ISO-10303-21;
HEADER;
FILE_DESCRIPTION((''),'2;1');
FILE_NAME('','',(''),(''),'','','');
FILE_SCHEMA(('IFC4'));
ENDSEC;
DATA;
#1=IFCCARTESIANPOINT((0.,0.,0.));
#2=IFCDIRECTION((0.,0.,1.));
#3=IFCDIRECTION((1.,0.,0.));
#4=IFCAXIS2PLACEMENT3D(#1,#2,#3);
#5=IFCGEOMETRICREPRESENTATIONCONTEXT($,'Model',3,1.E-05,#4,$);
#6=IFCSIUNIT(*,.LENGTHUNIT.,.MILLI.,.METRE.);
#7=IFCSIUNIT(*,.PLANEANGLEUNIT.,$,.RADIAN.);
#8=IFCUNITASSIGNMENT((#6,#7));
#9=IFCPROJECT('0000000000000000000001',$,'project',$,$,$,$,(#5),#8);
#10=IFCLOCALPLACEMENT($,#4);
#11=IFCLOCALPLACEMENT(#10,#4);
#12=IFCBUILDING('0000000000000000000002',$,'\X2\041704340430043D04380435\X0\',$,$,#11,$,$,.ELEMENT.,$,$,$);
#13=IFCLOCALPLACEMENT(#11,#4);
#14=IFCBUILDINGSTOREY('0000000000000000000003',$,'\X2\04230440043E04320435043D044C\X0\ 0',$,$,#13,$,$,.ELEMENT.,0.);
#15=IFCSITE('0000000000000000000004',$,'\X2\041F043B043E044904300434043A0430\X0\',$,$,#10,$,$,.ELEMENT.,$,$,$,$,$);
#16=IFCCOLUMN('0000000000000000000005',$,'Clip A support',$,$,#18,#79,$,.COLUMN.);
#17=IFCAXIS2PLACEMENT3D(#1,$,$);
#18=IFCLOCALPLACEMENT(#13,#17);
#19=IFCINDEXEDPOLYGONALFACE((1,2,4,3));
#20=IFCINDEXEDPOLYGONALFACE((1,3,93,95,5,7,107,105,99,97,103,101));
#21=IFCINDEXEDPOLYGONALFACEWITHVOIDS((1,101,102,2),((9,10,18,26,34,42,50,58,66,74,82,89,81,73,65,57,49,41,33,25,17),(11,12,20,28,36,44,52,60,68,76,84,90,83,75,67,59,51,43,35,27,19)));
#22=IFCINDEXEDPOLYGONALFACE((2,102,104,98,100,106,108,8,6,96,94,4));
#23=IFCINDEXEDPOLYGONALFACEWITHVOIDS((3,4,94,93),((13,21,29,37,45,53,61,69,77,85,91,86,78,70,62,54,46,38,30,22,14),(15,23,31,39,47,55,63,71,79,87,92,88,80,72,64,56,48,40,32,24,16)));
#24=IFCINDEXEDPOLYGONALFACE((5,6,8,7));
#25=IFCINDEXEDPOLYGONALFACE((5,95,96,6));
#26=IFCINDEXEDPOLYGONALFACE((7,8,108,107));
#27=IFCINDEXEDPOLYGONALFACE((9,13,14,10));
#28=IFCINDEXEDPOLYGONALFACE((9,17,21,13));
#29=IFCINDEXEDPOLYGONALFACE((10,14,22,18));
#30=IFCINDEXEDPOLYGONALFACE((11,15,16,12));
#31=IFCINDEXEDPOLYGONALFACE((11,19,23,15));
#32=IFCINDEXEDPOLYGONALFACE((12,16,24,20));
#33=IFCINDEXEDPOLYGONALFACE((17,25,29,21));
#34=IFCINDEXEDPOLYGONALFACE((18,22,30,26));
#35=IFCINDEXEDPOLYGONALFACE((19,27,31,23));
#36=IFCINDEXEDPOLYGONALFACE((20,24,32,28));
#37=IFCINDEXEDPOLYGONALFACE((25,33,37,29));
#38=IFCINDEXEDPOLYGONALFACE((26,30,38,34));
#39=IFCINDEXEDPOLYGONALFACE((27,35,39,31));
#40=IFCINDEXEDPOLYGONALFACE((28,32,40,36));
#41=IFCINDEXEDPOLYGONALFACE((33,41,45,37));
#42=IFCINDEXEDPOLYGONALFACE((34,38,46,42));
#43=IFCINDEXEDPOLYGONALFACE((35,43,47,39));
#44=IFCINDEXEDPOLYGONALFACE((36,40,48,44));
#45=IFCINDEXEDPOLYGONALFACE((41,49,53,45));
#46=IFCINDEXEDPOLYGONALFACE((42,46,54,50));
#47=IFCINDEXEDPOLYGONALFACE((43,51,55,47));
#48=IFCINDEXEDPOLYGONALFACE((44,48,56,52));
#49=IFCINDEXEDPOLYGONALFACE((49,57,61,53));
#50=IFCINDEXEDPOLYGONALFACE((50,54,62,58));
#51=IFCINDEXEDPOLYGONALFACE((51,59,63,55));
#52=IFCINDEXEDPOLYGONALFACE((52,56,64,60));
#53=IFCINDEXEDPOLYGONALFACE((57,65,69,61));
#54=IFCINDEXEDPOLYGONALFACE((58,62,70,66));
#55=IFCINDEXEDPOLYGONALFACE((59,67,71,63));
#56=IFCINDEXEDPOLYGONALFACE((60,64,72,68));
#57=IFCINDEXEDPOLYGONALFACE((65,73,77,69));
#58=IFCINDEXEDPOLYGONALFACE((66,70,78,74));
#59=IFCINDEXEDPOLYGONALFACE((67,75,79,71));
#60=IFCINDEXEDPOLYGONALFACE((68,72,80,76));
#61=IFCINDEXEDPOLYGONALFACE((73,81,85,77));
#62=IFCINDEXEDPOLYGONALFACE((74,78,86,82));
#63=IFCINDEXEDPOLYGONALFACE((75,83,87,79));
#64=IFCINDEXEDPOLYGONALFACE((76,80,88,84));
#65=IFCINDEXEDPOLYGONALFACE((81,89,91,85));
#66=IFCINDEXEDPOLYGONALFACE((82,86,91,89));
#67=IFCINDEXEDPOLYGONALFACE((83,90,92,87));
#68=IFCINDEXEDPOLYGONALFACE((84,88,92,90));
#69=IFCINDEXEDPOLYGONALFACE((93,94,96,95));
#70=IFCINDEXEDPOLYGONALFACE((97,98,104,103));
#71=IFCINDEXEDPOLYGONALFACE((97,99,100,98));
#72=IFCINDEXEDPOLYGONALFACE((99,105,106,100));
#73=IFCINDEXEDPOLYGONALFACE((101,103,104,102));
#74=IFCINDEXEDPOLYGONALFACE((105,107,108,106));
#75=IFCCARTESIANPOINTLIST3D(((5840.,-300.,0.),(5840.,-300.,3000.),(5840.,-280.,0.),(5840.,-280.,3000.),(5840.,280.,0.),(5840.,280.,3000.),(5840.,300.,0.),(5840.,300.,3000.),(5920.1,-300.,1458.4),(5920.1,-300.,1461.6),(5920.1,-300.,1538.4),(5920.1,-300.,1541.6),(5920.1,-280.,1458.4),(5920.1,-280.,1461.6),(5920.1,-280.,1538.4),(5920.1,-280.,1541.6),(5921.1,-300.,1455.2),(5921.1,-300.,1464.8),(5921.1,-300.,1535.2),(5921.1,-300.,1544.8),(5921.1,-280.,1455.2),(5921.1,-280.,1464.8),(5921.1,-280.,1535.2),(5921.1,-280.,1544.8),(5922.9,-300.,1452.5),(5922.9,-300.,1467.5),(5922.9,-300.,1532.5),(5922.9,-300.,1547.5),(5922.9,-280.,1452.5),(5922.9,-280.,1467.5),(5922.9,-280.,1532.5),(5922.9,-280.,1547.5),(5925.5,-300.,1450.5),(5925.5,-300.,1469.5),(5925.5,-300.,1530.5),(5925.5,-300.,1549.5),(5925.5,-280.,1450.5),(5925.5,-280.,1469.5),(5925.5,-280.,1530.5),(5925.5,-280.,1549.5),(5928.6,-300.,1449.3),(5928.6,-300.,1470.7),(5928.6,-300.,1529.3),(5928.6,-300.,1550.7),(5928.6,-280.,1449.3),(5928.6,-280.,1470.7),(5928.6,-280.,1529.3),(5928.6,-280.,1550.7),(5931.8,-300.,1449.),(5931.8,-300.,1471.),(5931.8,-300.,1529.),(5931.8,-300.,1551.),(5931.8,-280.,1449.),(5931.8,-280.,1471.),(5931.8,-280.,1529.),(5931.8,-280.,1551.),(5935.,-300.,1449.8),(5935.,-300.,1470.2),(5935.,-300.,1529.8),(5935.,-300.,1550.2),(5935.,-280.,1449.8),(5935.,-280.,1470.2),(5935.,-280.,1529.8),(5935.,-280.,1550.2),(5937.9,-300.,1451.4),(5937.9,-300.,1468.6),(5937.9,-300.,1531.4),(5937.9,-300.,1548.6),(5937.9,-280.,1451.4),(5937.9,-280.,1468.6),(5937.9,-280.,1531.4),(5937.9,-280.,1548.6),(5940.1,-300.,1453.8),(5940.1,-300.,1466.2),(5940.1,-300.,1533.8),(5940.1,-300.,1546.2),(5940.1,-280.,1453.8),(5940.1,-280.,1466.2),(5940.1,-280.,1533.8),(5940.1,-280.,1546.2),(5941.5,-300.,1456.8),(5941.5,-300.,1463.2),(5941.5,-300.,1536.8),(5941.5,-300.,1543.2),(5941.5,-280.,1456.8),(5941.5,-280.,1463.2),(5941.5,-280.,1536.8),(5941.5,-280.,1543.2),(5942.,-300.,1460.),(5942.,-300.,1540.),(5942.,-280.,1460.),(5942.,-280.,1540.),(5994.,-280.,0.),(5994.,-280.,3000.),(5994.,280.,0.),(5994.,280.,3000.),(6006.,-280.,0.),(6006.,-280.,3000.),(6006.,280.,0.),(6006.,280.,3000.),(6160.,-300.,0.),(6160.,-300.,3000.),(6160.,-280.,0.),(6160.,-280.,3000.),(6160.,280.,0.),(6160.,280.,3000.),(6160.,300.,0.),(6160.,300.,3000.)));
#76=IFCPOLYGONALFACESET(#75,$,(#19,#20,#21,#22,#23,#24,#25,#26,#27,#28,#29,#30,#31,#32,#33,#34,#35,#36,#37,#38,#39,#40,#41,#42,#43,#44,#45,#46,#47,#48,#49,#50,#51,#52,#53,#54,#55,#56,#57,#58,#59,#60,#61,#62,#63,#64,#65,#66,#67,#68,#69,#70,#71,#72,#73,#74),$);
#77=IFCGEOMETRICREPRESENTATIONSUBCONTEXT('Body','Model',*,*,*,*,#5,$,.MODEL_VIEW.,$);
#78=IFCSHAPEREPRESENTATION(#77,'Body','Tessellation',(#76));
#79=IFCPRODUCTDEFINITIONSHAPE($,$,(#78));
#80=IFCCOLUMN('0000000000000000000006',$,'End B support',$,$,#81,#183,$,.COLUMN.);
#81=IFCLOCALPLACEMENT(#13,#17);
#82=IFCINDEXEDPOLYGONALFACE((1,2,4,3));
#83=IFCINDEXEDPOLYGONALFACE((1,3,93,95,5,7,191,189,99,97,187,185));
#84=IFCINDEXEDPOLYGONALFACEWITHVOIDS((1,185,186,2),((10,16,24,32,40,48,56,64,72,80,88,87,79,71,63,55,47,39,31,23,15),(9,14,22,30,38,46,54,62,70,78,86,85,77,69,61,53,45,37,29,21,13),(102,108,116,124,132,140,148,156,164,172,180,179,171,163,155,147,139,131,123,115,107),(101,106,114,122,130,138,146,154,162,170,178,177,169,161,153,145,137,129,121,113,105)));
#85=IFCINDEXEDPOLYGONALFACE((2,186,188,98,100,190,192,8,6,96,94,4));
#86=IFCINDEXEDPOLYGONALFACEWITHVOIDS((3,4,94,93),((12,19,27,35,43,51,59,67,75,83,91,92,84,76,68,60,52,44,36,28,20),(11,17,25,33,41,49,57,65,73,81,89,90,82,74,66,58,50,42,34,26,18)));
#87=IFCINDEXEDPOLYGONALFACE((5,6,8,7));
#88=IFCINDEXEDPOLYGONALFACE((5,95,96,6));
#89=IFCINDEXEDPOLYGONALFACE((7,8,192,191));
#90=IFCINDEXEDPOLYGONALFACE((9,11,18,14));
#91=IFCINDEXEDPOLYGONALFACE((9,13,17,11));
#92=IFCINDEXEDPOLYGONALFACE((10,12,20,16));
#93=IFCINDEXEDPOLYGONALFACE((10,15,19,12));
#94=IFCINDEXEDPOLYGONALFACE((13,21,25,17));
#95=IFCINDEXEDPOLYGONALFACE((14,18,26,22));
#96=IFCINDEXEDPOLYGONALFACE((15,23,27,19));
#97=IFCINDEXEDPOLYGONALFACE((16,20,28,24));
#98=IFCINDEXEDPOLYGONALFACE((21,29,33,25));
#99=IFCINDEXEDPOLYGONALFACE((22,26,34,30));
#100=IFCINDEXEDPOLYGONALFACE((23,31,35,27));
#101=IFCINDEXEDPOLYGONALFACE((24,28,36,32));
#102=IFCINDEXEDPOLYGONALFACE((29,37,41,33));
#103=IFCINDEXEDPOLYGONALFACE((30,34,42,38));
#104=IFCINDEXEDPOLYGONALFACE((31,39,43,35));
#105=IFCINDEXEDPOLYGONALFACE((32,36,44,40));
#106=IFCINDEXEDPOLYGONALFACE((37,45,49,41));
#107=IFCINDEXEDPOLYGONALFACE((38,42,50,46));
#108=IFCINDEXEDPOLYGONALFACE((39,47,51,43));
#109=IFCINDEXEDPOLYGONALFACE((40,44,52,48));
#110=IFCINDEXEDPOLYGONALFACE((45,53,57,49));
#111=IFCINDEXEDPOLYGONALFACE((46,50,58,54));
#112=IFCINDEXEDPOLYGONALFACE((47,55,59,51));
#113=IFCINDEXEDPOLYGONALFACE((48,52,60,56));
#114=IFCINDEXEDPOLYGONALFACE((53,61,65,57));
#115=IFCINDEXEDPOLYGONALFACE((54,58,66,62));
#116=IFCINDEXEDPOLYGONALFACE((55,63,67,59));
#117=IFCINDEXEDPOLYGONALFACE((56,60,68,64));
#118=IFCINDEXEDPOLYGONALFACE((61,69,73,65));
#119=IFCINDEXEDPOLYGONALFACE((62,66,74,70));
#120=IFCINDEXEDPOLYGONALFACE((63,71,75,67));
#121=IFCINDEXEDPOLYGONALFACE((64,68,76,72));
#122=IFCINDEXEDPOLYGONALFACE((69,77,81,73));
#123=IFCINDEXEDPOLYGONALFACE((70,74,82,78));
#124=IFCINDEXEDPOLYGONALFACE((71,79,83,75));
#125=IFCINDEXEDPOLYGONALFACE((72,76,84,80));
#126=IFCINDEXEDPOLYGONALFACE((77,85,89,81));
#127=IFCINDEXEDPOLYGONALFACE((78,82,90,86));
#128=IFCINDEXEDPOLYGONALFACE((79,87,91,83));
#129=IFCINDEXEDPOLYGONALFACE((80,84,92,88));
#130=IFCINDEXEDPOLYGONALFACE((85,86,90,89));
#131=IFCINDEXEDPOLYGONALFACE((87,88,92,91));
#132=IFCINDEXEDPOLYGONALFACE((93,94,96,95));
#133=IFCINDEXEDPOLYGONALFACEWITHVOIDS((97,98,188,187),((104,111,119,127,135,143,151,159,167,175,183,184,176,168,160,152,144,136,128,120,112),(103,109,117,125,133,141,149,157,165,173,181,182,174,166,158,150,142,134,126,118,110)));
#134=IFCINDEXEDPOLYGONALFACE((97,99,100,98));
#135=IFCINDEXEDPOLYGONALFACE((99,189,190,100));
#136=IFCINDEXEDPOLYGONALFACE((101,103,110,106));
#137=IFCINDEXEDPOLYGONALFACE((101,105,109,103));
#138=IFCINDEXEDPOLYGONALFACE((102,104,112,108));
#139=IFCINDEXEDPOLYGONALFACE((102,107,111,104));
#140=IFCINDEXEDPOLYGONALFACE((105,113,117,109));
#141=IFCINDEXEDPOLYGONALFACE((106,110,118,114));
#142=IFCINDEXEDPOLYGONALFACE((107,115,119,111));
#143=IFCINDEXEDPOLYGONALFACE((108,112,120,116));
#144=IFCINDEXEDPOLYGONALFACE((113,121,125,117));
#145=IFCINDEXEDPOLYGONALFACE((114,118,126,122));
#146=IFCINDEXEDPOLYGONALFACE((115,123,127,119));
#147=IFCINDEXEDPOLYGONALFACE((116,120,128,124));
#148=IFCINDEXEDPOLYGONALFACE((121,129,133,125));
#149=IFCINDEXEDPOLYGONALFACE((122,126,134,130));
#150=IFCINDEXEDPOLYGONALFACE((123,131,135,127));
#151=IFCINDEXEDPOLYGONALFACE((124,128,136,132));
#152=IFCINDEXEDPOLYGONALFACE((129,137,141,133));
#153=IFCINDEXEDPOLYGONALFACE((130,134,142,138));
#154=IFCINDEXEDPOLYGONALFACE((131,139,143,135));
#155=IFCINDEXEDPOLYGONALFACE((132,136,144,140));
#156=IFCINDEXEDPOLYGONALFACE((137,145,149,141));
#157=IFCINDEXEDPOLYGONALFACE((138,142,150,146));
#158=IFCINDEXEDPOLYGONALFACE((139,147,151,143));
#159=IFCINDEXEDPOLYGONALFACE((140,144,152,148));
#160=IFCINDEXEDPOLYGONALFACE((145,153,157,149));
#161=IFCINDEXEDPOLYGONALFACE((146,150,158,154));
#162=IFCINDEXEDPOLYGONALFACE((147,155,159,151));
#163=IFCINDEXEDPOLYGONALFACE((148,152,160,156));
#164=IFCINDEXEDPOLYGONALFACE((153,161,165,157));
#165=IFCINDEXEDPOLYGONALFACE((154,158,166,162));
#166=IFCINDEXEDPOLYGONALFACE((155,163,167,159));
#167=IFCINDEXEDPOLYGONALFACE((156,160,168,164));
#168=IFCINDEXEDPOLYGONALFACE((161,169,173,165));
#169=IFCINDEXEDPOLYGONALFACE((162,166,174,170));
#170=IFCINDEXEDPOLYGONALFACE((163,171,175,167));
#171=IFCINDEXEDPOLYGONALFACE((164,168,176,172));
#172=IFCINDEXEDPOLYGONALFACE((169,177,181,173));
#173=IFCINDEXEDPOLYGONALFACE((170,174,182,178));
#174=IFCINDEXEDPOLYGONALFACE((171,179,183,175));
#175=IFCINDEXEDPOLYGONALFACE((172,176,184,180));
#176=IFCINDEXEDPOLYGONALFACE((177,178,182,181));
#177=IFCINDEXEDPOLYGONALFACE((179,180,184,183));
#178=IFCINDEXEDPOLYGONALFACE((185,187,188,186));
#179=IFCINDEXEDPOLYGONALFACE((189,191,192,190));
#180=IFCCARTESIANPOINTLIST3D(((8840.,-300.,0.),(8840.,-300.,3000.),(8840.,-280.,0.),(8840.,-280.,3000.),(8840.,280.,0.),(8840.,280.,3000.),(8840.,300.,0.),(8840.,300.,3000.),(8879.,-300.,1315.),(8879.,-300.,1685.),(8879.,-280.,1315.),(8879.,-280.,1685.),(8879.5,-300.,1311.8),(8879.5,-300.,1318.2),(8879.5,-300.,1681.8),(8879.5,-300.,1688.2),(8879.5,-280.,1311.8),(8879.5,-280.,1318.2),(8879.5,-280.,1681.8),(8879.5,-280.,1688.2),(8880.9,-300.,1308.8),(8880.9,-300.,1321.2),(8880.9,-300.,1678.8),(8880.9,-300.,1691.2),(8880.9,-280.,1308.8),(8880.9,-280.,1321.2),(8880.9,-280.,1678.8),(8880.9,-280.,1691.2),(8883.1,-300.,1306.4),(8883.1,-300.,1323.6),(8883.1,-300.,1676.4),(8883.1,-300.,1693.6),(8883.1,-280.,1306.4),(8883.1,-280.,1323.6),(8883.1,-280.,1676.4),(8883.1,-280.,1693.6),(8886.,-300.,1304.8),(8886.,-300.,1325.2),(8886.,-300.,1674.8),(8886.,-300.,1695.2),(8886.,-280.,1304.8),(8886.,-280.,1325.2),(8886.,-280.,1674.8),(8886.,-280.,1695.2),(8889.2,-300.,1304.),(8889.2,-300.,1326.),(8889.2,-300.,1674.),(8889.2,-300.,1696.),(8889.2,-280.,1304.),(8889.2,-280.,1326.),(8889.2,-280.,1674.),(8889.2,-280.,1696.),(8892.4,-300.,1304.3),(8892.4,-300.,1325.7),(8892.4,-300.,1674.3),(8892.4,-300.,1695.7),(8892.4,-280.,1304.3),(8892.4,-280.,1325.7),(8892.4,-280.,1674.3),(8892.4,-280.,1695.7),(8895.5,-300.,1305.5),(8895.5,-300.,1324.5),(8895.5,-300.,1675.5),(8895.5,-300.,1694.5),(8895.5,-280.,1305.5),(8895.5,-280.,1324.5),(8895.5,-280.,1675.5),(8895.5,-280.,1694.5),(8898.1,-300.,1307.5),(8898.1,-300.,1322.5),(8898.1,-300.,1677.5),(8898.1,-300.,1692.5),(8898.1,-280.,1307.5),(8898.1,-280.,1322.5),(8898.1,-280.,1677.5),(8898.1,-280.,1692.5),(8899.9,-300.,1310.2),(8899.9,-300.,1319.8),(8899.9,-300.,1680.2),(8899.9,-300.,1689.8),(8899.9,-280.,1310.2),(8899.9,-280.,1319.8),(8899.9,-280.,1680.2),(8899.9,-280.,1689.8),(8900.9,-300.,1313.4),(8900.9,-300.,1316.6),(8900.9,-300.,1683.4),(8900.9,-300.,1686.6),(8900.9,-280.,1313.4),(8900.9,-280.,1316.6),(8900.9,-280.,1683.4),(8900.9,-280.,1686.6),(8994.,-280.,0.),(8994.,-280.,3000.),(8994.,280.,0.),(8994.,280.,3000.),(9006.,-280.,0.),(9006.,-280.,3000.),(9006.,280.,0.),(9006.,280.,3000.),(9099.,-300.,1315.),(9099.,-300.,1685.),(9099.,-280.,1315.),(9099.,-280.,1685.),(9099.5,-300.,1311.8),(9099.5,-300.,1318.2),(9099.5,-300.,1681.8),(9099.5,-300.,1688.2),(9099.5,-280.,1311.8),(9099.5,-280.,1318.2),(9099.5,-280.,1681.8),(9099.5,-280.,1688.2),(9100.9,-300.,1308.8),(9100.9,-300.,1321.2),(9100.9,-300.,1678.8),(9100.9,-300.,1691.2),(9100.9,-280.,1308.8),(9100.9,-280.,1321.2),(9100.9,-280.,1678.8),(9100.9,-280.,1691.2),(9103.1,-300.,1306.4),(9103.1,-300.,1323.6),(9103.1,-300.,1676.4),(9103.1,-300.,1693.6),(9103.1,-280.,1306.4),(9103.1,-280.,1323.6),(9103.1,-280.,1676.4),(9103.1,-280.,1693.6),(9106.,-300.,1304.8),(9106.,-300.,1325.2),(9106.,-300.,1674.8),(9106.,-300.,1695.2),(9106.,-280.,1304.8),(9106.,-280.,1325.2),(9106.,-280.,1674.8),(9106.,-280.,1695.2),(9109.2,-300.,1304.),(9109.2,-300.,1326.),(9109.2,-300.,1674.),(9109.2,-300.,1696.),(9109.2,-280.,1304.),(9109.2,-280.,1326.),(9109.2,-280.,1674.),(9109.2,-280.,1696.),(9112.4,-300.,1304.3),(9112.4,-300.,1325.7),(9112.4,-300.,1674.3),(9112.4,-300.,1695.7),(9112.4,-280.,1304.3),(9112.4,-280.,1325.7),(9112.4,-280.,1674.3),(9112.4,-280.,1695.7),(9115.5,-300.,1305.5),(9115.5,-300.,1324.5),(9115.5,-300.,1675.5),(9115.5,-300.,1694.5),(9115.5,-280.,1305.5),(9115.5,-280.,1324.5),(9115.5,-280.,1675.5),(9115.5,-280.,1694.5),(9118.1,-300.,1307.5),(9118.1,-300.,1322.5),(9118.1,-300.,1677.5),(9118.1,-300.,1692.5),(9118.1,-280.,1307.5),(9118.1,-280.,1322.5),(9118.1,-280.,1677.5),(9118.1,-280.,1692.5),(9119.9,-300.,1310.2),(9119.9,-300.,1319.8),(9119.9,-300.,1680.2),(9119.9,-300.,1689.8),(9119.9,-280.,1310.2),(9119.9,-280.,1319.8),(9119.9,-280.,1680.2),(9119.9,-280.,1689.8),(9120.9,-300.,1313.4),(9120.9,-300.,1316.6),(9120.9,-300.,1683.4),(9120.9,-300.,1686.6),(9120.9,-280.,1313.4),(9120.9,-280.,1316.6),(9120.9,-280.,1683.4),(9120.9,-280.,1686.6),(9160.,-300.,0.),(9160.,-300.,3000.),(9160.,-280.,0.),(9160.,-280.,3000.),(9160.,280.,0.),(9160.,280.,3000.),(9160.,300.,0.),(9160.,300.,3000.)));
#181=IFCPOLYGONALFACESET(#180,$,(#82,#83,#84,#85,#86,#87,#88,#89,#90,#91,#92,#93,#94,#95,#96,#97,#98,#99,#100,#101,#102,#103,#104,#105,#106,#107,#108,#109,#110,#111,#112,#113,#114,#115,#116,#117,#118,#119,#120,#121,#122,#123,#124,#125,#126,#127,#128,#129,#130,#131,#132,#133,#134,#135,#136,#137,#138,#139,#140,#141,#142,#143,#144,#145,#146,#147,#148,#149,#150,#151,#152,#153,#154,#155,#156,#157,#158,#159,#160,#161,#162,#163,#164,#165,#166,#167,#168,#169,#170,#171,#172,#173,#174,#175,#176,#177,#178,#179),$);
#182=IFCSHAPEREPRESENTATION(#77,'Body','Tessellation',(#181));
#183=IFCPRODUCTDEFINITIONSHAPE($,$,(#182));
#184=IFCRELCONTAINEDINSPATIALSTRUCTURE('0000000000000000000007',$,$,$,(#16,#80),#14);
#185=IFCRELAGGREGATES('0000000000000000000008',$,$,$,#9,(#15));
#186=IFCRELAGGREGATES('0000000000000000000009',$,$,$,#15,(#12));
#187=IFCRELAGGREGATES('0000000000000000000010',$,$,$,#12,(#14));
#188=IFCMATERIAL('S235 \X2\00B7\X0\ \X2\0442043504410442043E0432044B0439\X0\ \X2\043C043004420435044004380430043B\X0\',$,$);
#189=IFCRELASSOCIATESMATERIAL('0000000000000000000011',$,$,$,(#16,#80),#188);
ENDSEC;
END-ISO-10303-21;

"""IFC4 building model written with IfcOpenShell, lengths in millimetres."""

from ifc_helpers import new_model, si_unit, frame, origin_with_axes, place, context, subcontext, project, spatial, circle, i_section, extrude, material, element, save


model = new_model("IFC4")

# Units and contexts
model_context = context("Model", 3, precision=1e-05, world=origin_with_axes())
body_context = subcontext(model_context, "Body", "Model", "MODEL_VIEW")
ifc_project = project(units=[si_unit("LENGTHUNIT", "METRE", prefix="MILLI"), si_unit("PLANEANGLEUNIT", "RADIAN")], contexts=[model_context])

# Site, building, storey
site_placement = place(None, origin_with_axes())
site = spatial("IfcSite", under=ifc_project, at=site_placement, Name="Площадка", CompositionType="ELEMENT")
building_placement = place(site_placement, origin_with_axes())
building = spatial("IfcBuilding", under=site, at=building_placement, Name="Здание", CompositionType="ELEMENT")
storey_placement = place(building_placement, origin_with_axes())
storey = spatial("IfcBuildingStorey", under=building, at=storey_placement, Name="Уровень 0", CompositionType="ELEMENT", Elevation=0.0)

# Columns, openings
ifc_material = material(Name="S235 · тестовый материал")
column_1_placement = place(storey_placement, frame((6000.0, 0.0, 0.0), z_axis=(0.0, 0.0, 1.0), x_axis=(1.0, 0.0, 0.0)))
column_1 = element("IfcColumn", 1, at=column_1_placement, inside=storey, material=ifc_material, Name="Clip A support", PredefinedType="COLUMN", context=body_context, shape_type="SweptSolid", body=[
    extrude(i_section(OverallWidth=320.0, OverallDepth=600.0, WebThickness=12.0, FlangeThickness=20.0), origin_with_axes(), (0.0, 0.0, 1.0), 3000.0),
])
opening_1_placement = place(column_1_placement, frame((-69.0, -321.0, 1540.0), z_axis=(0.0, 1.0, 0.0), x_axis=(1.0, 0.0, 0.0)))
element("IfcOpeningElement", 2, at=opening_1_placement, cuts=column_1, PredefinedType="OPENING", context=body_context, shape_type="SweptSolid", body=[
    extrude(circle(Radius=11.0), origin_with_axes(), (0.0, 0.0, 1.0), 42.0),
])
opening_2_placement = place(column_1_placement, frame((-69.0, -321.0, 1460.0), z_axis=(0.0, 1.0, 0.0), x_axis=(1.0, 0.0, 0.0)))
element("IfcOpeningElement", 3, at=opening_2_placement, cuts=column_1, PredefinedType="OPENING", context=body_context, shape_type="SweptSolid", body=[
    extrude(circle(Radius=11.0), origin_with_axes(), (0.0, 0.0, 1.0), 42.0),
])
column_2_placement = place(storey_placement, frame((9000.0, 0.0, 0.0), z_axis=(0.0, 0.0, 1.0), x_axis=(1.0, 0.0, 0.0)))
column_2 = element("IfcColumn", 4, at=column_2_placement, inside=storey, material=ifc_material, Name="End B support", PredefinedType="COLUMN", context=body_context, shape_type="SweptSolid", body=[
    extrude(i_section(OverallWidth=320.0, OverallDepth=600.0, WebThickness=12.0, FlangeThickness=20.0), origin_with_axes(), (0.0, 0.0, 1.0), 3000.0),
])
opening_3_placement = place(column_2_placement, frame((110.0, -321.0, 1315.0), z_axis=(0.0, 1.0, 0.0), x_axis=(-1.0, 0.0, 0.0)))
element("IfcOpeningElement", 5, at=opening_3_placement, cuts=column_2, PredefinedType="OPENING", context=body_context, shape_type="SweptSolid", body=[
    extrude(circle(Radius=11.0), origin_with_axes(), (0.0, 0.0, 1.0), 42.0),
])
opening_4_placement = place(column_2_placement, frame((110.0, -321.0, 1685.0), z_axis=(0.0, 1.0, 0.0), x_axis=(-1.0, 0.0, 0.0)))
element("IfcOpeningElement", 6, at=opening_4_placement, cuts=column_2, PredefinedType="OPENING", context=body_context, shape_type="SweptSolid", body=[
    extrude(circle(Radius=11.0), origin_with_axes(), (0.0, 0.0, 1.0), 42.0),
])
opening_5_placement = place(column_2_placement, frame((-110.0, -321.0, 1315.0), z_axis=(0.0, 1.0, 0.0), x_axis=(-1.0, 0.0, 0.0)))
element("IfcOpeningElement", 7, at=opening_5_placement, cuts=column_2, PredefinedType="OPENING", context=body_context, shape_type="SweptSolid", body=[
    extrude(circle(Radius=11.0), origin_with_axes(), (0.0, 0.0, 1.0), 42.0),
])
opening_6_placement = place(column_2_placement, frame((-110.0, -321.0, 1685.0), z_axis=(0.0, 1.0, 0.0), x_axis=(-1.0, 0.0, 0.0)))
element("IfcOpeningElement", 8, at=opening_6_placement, cuts=column_2, PredefinedType="OPENING", context=body_context, shape_type="SweptSolid", body=[
    extrude(circle(Radius=11.0), origin_with_axes(), (0.0, 0.0, 1.0), 42.0),
])

save(model, "model.ifc")
